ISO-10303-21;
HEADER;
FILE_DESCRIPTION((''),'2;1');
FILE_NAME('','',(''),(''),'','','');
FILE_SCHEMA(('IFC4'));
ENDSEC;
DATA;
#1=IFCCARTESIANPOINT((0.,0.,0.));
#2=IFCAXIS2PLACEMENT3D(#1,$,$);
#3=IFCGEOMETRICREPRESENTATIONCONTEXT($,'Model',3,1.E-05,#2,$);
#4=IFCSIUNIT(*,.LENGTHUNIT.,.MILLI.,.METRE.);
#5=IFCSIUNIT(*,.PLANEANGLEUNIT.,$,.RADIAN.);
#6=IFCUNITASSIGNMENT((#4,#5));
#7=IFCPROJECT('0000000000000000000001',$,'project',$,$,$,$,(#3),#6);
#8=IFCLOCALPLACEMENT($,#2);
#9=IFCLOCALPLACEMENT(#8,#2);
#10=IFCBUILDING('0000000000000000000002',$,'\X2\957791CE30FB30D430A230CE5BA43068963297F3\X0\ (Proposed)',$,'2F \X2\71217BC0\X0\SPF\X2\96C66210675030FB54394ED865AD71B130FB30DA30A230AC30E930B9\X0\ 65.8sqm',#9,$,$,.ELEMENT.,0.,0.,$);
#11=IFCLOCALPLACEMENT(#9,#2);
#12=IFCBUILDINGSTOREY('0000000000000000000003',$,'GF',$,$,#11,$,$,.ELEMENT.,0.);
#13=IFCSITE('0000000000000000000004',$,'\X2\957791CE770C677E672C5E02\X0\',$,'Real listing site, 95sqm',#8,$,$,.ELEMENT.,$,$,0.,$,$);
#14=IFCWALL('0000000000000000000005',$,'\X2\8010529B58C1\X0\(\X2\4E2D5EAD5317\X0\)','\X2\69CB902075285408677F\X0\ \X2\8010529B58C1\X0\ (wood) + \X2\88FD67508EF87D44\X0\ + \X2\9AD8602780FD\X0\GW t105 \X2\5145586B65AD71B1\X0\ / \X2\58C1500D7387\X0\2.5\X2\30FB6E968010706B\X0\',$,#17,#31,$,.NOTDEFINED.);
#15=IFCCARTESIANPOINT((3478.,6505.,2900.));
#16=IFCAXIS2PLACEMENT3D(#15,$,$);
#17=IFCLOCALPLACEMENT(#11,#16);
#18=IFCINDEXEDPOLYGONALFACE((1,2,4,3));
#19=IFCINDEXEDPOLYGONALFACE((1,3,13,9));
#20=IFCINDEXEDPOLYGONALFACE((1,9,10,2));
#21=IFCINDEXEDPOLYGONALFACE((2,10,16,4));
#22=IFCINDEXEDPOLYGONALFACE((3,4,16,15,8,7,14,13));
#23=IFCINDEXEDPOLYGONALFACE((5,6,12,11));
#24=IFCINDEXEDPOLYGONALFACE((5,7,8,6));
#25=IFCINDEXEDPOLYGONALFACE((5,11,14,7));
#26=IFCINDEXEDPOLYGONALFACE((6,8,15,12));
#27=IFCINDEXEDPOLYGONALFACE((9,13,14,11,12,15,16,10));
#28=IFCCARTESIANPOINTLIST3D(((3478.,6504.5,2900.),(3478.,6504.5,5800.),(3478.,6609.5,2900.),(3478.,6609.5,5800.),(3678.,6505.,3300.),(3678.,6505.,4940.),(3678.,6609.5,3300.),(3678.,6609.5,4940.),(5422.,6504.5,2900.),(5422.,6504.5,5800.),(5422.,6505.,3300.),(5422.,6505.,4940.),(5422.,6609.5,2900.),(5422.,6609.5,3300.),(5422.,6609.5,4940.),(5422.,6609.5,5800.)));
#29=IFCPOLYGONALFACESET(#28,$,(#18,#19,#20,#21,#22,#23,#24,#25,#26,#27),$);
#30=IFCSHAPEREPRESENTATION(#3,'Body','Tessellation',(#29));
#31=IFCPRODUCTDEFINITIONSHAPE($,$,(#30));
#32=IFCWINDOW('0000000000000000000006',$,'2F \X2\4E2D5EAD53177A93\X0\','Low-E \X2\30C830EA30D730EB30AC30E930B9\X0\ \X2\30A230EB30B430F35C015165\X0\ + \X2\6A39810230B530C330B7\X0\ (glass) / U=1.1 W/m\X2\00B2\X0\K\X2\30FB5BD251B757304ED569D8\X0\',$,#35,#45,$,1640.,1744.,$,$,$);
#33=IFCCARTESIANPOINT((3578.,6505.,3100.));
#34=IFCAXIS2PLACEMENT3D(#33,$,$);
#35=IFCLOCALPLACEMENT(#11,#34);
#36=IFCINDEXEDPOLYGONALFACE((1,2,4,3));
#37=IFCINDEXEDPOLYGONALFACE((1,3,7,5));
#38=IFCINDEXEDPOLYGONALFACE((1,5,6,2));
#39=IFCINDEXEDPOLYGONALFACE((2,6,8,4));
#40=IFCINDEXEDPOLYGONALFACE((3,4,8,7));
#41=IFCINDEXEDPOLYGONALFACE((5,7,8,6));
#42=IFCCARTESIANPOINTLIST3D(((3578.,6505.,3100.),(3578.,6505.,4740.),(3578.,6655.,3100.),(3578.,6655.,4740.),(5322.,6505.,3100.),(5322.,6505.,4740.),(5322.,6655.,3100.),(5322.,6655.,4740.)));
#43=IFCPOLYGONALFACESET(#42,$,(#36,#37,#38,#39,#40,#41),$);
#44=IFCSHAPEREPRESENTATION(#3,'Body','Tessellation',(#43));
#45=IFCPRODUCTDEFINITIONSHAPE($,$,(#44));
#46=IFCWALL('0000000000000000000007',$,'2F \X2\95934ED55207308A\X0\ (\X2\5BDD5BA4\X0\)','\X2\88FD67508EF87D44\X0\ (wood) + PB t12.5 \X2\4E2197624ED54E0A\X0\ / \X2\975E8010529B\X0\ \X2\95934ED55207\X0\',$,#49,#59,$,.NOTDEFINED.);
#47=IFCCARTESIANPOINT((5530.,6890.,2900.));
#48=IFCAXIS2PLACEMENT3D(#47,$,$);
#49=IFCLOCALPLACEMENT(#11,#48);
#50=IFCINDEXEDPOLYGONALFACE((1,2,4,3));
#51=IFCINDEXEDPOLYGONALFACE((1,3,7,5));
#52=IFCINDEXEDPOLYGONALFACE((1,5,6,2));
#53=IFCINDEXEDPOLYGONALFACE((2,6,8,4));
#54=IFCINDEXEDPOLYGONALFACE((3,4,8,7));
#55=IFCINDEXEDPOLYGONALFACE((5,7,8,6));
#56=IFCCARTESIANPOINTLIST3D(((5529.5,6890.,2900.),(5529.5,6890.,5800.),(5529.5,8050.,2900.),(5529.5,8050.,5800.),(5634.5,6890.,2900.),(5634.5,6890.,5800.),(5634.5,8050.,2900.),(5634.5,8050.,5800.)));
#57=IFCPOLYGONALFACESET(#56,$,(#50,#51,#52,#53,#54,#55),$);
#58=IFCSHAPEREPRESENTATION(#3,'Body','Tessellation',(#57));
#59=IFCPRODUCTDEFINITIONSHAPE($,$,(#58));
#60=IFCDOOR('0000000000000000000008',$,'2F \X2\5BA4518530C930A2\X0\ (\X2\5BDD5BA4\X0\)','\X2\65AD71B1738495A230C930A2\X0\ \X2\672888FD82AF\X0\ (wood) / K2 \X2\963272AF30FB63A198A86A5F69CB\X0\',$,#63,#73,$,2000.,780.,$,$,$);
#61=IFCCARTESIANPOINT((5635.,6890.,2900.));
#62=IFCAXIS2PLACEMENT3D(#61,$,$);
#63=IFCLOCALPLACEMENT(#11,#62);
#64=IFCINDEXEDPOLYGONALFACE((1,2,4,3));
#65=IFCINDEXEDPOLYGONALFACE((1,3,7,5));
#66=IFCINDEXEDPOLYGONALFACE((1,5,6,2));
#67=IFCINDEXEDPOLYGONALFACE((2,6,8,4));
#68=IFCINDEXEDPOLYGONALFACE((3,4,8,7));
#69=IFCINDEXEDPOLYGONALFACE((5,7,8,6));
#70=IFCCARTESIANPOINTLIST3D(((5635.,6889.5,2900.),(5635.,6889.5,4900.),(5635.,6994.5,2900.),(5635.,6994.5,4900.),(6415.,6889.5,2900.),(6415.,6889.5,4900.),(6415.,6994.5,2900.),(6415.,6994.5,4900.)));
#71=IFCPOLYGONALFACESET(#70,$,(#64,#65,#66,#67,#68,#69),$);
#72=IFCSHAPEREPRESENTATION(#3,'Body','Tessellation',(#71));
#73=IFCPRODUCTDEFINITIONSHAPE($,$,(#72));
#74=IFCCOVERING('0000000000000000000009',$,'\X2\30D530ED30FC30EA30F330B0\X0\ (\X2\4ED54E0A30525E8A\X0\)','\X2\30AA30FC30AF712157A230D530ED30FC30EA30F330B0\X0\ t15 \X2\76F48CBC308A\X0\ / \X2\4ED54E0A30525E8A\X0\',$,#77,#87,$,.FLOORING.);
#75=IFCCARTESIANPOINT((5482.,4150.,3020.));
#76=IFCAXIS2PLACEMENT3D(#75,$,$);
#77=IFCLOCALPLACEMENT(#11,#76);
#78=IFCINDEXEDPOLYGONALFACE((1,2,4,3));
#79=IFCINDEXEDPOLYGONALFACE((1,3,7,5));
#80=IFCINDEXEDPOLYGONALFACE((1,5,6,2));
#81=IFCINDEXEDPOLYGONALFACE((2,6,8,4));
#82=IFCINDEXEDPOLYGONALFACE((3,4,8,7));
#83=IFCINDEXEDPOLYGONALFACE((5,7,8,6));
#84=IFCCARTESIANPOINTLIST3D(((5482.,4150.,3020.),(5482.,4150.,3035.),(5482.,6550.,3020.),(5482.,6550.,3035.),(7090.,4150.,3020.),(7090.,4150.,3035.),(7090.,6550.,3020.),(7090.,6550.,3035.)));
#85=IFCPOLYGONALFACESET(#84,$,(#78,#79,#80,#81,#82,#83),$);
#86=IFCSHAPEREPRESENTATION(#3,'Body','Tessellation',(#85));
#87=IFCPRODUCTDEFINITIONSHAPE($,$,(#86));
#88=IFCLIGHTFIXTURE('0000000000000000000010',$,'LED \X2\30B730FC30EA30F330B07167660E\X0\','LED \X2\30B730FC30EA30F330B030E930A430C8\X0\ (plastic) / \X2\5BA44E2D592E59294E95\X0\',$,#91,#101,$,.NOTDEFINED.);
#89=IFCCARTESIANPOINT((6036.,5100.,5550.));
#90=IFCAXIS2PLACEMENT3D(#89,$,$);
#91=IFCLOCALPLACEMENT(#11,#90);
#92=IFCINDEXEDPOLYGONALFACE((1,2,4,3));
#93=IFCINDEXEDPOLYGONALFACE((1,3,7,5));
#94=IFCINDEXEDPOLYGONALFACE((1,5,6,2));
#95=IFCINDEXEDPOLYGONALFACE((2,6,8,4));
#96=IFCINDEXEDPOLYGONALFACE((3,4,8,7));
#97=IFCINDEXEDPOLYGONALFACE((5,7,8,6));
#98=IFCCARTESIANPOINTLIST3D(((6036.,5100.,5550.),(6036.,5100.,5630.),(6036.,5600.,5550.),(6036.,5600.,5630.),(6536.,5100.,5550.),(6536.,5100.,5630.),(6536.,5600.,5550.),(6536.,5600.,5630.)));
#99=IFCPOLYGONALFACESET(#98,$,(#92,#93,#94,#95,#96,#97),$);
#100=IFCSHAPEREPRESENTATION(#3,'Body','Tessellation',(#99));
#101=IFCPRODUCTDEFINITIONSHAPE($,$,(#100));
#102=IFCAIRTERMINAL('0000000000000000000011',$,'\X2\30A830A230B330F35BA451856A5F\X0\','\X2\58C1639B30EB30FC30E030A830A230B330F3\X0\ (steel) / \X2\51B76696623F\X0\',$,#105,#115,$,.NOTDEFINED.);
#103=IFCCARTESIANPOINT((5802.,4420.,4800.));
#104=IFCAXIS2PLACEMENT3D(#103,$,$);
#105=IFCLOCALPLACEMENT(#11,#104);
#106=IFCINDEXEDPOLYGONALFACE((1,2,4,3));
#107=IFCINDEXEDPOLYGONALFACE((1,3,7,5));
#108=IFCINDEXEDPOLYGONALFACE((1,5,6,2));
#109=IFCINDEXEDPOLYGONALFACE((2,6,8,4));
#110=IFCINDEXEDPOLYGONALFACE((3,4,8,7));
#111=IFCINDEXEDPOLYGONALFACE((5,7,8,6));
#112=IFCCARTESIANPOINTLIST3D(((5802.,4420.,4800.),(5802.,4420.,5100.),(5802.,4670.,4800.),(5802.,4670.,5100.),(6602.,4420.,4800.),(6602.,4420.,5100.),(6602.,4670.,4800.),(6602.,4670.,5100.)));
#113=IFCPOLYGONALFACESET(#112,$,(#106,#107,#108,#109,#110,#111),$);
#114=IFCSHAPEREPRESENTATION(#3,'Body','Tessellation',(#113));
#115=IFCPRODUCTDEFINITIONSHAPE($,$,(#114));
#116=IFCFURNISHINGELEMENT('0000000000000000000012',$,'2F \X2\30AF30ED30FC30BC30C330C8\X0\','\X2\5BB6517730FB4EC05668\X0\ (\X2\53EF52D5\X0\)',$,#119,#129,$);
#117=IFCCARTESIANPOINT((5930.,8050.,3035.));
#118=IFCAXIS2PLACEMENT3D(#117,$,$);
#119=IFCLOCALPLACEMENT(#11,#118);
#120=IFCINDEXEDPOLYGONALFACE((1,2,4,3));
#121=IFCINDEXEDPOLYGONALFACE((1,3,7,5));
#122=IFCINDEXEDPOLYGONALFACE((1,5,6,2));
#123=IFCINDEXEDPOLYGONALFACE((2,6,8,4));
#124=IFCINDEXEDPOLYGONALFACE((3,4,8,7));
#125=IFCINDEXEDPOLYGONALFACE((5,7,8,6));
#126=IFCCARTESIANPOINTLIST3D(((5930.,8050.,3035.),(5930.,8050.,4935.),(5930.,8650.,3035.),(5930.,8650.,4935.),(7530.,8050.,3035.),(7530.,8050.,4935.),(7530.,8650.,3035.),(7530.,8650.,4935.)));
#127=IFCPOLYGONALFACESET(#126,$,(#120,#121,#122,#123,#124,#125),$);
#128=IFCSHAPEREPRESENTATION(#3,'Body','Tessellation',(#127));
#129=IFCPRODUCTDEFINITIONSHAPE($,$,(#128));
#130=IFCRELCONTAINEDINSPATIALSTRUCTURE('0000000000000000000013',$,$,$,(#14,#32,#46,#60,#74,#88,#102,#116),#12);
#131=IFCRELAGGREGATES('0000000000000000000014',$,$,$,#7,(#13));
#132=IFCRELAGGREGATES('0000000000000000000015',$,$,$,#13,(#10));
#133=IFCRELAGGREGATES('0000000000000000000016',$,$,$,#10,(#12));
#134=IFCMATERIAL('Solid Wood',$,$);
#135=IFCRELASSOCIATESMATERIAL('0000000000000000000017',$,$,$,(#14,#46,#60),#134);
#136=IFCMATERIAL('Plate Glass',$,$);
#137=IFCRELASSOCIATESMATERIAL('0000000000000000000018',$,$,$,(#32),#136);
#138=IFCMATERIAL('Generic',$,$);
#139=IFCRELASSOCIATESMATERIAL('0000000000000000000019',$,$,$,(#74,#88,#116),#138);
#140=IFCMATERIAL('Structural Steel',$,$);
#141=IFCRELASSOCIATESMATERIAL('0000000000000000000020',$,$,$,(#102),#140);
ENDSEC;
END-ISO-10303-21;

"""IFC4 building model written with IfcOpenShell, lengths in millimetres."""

from ifc_helpers import new_model, si_unit, frame, frame_2d, origin, place, context, project, spatial, rectangle, extrude, material, element, fill, save


model = new_model("IFC4")

# Units and contexts
model_context = context("Model", 3, precision=1e-05, world=origin())
ifc_project = project(units=[si_unit("LENGTHUNIT", "METRE", prefix="MILLI"), si_unit("PLANEANGLEUNIT", "RADIAN")], contexts=[model_context])

# Site, building, storey
site_placement = place(None, origin())
site = spatial("IfcSite", under=ifc_project, at=site_placement, Name="長野県松本市", ObjectType="Real listing site, 95sqm", CompositionType="ELEMENT", RefElevation=0.0)
building_placement = place(site_placement, origin())
building = spatial("IfcBuilding", under=site, at=building_placement, Name="長野・ピアノ室と防音 (Proposed)", ObjectType="2F 無節SPF集成材・吹付断熱・ペアガラス 65.8sqm", CompositionType="ELEMENT", ElevationOfRefHeight=0.0, ElevationOfTerrain=0.0)
storey_placement = place(building_placement, origin())
storey = spatial("IfcBuildingStorey", under=building, at=storey_placement, Name="GF", CompositionType="ELEMENT", Elevation=0.0)

# Shared definitions
ifc_material_1 = material(Name="Solid Wood")

# Wall, opening, window
wall_1_placement = place(storey_placement, frame((3478.0, 6505.0, 2900.0)))
wall_1 = element("IfcWall", 1, at=wall_1_placement, inside=storey, material=ifc_material_1, Name="耐力壁(中庭北)", Description="構造用合板 耐力壁 (wood) + 製材軸組 + 高性能GW t105 充填断熱 / 壁倍率2.5・準耐火", PredefinedType="NOTDEFINED", context=model_context, shape_type="SweptSolid", body=[
    extrude(rectangle(XDim=1944.0, YDim=105.0, at=frame_2d((972.0, 52.0))), frame((3478.0, 6505.0, 2900.0)), (0.0, 0.0, 1.0), 2900.0),
])
opening_placement = place(storey_placement, frame((3578.0, 6505.0, 3100.0)))
opening = element("IfcOpeningElement", 2, at=opening_placement, cuts=wall_1, PredefinedType="NOTDEFINED", context=model_context, shape_type="SweptSolid", body=[
    extrude(rectangle(XDim=1744.0, YDim=150.0, at=frame_2d((872.0, 75.0))), frame((3578.0, 6505.0, 3100.0)), (0.0, 0.0, 1.0), 1640.0),
])
ifc_material_2 = material(Name="Plate Glass")
window_placement = place(storey_placement, frame((3578.0, 6505.0, 3100.0)))
window = element("IfcWindow", 3, at=window_placement, inside=storey, material=ifc_material_2, Name="2F 中庭北窓", Description="Low-E トリプルガラス アルゴン封入 + 樹脂サッシ (glass) / U=1.1 W/m²K・寒冷地仕様", OverallHeight=1640.0, OverallWidth=1744.0, context=model_context, shape_type="SweptSolid", body=[
    extrude(rectangle(XDim=1744.0, YDim=150.0, at=frame_2d((872.0, 75.0))), frame((3578.0, 6505.0, 3100.0)), (0.0, 0.0, 1.0), 1640.0),
])
fill(opening, window)

# Wall
wall_2_placement = place(storey_placement, frame((5530.0, 6890.0, 2900.0)))
element("IfcWall", 4, at=wall_2_placement, inside=storey, material=ifc_material_1, Name="2F 間仕切り (寝室)", Description="製材軸組 (wood) + PB t12.5 両面仕上 / 非耐力 間仕切", PredefinedType="NOTDEFINED", context=model_context, shape_type="SweptSolid", body=[
    extrude(rectangle(XDim=105.0, YDim=1160.0, at=frame_2d((52.0, 580.0))), frame((5530.0, 6890.0, 2900.0)), (0.0, 0.0, 1.0), 2900.0),
])

# Door
door_placement = place(storey_placement, frame((5635.0, 6890.0, 2900.0)))
element("IfcDoor", 5, at=door_placement, inside=storey, material=ifc_material_1, Name="2F 室内ドア (寝室)", Description="断熱玄関ドア 木製芯 (wood) / K2 防犯・採風機構", OverallHeight=2000.0, OverallWidth=780.0, context=model_context, shape_type="SweptSolid", body=[
    extrude(rectangle(XDim=780.0, YDim=105.0, at=frame_2d((390.0, 52.0))), frame((5635.0, 6890.0, 2900.0)), (0.0, 0.0, 1.0), 2000.0),
])

# Covering
ifc_material_3 = material(Name="Generic")
covering_placement = place(storey_placement, frame((5482.0, 4150.0, 3020.0)))
element("IfcCovering", 6, at=covering_placement, inside=storey, material=ifc_material_3, Name="フローリング (仕上げ床)", Description="オーク無垢フローリング t15 直貼り / 仕上げ床", PredefinedType="FLOORING", context=model_context, shape_type="SweptSolid", body=[
    extrude(rectangle(XDim=1608.0, YDim=2400.0, at=frame_2d((804.0, 1200.0))), frame((5482.0, 4150.0, 3020.0)), (0.0, 0.0, 1.0), 15.0),
])

# Light fixture
light_fixture_placement = place(storey_placement, frame((6036.0, 5100.0, 5550.0)))
element("IfcLightFixture", 7, at=light_fixture_placement, inside=storey, material=ifc_material_3, Name="LED シーリング照明", Description="LED シーリングライト (plastic) / 室中央天井", PredefinedType="NOTDEFINED", context=model_context, shape_type="SweptSolid", body=[
    extrude(rectangle(XDim=500.0, YDim=500.0, at=frame_2d((250.0, 250.0))), frame((6036.0, 5100.0, 5550.0)), (0.0, 0.0, 1.0), 80.0),
])

# Air terminal
ifc_material_4 = material(Name="Structural Steel")
air_terminal_placement = place(storey_placement, frame((5802.0, 4420.0, 4800.0)))
element("IfcAirTerminal", 8, at=air_terminal_placement, inside=storey, material=ifc_material_4, Name="エアコン室内機", Description="壁掛ルームエアコン (steel) / 冷暖房", PredefinedType="NOTDEFINED", context=model_context, shape_type="SweptSolid", body=[
    extrude(rectangle(XDim=800.0, YDim=250.0, at=frame_2d((400.0, 125.0))), frame((5802.0, 4420.0, 4800.0)), (0.0, 0.0, 1.0), 300.0),
])

# Furnishing element
furnishing_placement = place(storey_placement, frame((5930.0, 8050.0, 3035.0)))
element("IfcFurnishingElement", 9, at=furnishing_placement, inside=storey, material=ifc_material_3, Name="2F クローゼット", Description="家具・什器 (可動)", context=model_context, shape_type="SweptSolid", body=[
    extrude(rectangle(XDim=1600.0, YDim=600.0, at=frame_2d((800.0, 300.0))), frame((5930.0, 8050.0, 3035.0)), (0.0, 0.0, 1.0), 1900.0),
])

save(model, "model.ifc")
